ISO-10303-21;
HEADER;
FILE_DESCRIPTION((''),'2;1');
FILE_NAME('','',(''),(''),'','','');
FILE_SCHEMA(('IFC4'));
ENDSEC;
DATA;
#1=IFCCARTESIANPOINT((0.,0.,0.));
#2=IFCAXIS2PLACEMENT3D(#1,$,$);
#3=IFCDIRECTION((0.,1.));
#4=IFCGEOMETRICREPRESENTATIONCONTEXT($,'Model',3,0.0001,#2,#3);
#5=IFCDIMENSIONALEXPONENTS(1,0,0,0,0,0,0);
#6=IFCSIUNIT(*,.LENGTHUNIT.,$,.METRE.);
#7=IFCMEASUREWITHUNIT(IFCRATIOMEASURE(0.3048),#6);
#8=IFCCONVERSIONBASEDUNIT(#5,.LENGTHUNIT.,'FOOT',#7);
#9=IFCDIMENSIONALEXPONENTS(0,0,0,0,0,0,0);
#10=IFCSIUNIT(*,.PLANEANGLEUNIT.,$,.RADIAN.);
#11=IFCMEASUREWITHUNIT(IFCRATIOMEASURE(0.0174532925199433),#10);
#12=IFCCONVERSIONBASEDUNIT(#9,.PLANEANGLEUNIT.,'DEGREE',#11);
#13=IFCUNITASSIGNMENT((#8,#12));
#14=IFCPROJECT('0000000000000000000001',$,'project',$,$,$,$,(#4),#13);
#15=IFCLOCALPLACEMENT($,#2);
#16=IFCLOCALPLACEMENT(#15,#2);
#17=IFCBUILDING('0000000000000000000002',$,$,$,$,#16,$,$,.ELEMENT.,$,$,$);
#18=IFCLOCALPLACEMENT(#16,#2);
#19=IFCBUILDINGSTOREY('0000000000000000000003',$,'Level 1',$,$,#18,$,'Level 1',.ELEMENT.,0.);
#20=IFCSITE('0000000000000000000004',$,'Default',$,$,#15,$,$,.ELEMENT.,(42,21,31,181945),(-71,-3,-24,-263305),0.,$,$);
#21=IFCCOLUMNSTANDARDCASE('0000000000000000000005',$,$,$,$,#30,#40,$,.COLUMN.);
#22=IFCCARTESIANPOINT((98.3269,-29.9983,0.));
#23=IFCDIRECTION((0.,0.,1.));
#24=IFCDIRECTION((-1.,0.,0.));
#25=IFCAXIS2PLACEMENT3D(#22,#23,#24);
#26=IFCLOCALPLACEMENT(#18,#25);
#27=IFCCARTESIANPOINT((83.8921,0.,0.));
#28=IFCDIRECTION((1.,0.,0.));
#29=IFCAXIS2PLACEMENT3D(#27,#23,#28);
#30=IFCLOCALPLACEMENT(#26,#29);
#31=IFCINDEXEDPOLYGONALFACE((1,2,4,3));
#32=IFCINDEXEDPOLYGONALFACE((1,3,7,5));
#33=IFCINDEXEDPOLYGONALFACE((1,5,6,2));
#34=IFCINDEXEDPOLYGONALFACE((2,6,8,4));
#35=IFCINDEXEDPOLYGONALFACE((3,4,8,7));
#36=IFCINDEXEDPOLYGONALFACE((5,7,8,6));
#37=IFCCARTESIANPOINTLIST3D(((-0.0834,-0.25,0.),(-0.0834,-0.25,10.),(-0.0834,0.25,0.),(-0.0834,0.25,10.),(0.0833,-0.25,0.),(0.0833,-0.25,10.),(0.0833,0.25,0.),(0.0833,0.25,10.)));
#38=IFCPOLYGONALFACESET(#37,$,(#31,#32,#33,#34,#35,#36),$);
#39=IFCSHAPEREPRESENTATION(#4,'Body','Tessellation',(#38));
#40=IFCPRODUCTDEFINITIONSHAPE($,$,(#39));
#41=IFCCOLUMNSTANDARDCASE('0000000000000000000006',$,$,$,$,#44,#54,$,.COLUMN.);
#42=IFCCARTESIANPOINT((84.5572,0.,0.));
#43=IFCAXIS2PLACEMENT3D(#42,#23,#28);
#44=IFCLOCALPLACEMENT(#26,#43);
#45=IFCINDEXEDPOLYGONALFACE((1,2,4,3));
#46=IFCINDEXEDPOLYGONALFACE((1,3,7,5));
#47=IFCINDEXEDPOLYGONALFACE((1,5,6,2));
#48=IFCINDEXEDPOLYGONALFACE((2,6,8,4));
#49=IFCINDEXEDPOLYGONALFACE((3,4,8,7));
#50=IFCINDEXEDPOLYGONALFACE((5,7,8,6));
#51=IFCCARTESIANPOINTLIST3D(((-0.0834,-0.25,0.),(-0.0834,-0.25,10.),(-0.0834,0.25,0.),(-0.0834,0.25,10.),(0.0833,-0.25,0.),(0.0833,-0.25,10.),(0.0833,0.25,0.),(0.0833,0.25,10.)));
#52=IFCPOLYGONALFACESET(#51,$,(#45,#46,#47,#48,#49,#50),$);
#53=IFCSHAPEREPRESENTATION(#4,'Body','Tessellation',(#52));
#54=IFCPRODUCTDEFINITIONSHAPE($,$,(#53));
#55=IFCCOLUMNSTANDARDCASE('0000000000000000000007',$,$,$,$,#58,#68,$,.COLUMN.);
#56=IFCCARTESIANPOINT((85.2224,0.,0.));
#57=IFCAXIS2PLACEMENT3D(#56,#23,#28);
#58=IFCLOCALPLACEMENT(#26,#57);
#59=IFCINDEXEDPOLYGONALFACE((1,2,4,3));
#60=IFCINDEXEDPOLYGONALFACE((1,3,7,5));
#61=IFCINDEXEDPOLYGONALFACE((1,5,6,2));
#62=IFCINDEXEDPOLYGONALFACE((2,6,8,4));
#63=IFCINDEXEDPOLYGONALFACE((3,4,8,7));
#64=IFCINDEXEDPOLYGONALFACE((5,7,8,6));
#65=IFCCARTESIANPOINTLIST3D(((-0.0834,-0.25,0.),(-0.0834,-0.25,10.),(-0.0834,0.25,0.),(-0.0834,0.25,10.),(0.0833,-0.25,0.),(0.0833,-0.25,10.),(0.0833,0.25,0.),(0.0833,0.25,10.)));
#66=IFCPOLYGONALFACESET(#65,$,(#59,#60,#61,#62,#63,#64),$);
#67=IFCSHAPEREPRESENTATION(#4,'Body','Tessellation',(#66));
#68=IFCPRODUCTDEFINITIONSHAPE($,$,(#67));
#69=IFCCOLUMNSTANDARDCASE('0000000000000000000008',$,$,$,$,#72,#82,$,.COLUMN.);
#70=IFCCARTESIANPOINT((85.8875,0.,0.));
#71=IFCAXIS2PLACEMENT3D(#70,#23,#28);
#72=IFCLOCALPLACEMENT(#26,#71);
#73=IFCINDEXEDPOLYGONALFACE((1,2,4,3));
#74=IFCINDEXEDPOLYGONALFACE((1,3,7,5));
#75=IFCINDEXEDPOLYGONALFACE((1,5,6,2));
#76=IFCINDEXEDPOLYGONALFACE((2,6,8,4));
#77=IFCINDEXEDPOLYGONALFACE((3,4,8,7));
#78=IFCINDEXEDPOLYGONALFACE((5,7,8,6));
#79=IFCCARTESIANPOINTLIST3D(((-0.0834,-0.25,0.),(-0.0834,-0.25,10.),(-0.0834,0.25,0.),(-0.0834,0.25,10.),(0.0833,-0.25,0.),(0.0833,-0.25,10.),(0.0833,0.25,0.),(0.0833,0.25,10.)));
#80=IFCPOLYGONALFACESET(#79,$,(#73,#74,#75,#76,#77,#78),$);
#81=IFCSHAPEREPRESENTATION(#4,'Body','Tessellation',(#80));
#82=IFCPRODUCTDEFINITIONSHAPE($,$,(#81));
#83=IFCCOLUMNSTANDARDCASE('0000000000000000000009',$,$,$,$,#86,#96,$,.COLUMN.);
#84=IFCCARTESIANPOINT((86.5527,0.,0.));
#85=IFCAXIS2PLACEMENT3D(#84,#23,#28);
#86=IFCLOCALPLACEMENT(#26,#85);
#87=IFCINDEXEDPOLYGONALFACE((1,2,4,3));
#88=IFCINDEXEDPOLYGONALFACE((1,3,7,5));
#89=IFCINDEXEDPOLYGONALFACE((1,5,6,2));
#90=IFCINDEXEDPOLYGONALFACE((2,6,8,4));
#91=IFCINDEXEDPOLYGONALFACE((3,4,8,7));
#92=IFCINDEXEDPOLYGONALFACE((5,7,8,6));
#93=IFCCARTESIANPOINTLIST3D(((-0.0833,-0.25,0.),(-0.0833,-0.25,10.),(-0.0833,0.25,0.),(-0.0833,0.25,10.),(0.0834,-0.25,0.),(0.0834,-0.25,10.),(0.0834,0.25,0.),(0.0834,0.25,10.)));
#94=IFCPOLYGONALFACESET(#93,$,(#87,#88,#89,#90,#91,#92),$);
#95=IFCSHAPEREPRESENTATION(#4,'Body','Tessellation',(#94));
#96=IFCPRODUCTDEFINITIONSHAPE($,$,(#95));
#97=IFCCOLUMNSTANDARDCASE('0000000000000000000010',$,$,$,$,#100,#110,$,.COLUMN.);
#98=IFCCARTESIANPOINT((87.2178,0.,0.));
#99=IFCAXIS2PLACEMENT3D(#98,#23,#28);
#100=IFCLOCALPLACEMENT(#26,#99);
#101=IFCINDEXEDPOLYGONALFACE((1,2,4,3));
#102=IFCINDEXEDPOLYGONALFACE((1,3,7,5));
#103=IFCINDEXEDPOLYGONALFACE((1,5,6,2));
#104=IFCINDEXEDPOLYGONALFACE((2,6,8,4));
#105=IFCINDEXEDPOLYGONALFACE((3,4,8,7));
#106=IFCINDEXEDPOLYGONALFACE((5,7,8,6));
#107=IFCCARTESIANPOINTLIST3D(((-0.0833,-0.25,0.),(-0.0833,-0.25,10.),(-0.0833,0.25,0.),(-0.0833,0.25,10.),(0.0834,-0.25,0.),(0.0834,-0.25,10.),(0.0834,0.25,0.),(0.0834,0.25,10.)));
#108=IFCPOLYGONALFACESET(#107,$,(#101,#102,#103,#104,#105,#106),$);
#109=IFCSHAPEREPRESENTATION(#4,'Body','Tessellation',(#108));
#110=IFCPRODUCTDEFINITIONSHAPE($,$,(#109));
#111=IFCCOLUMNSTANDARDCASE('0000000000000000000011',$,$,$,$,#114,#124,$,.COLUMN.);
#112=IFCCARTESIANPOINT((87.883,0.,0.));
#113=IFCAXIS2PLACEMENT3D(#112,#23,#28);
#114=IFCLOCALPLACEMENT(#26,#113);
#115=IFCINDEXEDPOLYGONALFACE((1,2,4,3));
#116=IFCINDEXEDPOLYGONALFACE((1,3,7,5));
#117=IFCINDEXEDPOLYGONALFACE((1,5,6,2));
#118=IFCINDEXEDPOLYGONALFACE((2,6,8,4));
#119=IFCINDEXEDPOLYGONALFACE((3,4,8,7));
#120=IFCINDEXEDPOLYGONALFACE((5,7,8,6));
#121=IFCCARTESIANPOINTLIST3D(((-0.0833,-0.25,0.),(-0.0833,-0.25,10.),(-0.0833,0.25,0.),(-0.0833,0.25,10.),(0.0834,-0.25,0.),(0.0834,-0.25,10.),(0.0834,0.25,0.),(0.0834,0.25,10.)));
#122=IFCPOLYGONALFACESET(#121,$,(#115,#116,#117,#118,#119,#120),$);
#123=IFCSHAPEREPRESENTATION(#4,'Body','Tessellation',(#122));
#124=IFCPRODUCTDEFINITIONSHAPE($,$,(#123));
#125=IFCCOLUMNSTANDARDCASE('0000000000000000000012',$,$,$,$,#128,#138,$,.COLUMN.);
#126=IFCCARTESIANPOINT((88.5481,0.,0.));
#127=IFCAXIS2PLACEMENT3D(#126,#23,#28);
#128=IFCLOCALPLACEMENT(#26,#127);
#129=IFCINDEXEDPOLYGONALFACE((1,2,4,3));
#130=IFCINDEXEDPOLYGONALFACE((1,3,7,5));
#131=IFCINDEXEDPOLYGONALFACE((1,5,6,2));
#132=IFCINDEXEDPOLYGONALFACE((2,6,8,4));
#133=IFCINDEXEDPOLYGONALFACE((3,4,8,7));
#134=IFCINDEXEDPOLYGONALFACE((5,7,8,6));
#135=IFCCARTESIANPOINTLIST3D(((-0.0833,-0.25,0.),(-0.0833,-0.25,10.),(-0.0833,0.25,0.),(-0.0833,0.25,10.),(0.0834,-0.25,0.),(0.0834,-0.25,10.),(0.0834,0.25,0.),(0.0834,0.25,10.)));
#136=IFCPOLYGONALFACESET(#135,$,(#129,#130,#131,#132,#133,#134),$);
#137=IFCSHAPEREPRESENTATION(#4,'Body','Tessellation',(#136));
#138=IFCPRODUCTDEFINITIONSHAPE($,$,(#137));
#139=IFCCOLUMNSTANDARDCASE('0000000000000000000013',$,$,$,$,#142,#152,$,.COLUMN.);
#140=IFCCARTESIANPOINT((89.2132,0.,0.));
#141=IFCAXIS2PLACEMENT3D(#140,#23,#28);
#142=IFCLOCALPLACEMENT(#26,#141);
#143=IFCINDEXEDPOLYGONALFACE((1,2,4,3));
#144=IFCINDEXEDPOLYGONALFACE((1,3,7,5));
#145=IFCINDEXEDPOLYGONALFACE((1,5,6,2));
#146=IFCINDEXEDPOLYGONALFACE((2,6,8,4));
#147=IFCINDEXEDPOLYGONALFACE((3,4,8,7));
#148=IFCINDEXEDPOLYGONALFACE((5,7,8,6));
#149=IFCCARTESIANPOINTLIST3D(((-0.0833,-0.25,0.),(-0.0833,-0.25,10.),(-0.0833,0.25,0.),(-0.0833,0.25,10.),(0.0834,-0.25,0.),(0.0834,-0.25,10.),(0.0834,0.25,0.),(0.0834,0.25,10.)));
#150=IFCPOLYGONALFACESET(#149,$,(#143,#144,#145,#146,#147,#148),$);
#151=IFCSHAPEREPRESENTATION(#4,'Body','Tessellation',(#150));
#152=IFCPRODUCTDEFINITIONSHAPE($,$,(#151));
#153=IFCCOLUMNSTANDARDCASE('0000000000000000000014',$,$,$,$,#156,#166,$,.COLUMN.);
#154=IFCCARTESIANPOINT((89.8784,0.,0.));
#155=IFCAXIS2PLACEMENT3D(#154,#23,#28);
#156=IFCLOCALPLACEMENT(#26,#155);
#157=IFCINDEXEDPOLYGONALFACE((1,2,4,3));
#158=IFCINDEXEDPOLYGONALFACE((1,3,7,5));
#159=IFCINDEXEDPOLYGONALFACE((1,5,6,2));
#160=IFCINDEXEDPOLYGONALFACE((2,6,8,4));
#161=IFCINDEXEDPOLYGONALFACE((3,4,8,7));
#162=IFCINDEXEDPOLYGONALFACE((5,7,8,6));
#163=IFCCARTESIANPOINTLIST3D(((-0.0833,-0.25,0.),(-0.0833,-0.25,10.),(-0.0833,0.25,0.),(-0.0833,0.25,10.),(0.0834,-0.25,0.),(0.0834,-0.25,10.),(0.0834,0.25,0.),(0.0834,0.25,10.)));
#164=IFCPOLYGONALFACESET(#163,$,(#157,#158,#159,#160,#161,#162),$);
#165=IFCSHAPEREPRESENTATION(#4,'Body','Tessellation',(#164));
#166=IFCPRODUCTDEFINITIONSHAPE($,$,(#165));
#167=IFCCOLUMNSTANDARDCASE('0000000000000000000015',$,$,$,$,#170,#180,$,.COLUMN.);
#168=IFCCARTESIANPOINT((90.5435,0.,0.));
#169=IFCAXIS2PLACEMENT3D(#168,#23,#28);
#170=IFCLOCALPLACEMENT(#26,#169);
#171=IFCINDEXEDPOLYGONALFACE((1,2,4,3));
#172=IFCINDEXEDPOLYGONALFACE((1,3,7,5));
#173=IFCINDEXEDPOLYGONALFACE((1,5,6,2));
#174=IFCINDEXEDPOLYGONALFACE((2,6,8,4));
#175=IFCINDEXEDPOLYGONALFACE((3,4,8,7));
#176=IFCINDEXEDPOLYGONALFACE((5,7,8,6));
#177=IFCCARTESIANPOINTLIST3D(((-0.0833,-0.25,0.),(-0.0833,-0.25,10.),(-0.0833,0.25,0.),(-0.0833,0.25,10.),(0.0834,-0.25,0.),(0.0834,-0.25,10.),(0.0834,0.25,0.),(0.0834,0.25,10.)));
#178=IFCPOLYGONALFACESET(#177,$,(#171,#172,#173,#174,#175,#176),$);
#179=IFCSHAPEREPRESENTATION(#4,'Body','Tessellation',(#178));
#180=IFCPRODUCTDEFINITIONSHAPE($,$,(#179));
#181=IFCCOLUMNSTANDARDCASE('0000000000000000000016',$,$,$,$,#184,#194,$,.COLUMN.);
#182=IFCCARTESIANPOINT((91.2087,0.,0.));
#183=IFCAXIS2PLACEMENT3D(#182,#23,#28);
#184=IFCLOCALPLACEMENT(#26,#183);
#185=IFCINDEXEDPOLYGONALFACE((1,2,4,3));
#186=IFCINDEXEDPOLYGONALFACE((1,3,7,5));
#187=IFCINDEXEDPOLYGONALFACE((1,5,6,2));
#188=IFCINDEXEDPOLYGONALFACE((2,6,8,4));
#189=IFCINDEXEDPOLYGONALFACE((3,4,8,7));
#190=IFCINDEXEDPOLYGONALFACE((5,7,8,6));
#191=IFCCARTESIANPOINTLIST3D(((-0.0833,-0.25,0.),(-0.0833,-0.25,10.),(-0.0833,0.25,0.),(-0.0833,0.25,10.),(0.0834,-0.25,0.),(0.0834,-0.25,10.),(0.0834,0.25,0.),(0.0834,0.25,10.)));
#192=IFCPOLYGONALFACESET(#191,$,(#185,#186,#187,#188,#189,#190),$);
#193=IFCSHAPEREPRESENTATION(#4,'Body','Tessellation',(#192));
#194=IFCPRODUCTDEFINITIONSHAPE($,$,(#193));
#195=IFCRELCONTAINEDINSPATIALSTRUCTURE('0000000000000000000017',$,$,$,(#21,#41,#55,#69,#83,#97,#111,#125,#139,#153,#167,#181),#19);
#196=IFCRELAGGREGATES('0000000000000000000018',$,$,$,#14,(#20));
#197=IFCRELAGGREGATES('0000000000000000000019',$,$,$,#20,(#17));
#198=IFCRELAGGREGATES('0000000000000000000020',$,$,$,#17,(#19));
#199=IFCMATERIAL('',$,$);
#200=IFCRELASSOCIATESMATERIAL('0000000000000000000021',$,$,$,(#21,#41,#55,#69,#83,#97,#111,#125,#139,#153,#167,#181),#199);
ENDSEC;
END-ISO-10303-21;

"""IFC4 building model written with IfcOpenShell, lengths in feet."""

from ifc_helpers import new_model, entity, si_unit, converted_unit, direction, frame, origin, place, context, project, spatial, rectangle, extrude, material, element, save


model = new_model("IFC4")

# Units and contexts
model_context = context("Model", 3, precision=0.0001, world=origin(), true_north=direction((0.0, 1.0)))
ifc_project = project(units=[converted_unit("LENGTHUNIT", "FOOT", entity("IfcRatioMeasure", 0.3048), si_unit("LENGTHUNIT", "METRE"), dimensions=[1, 0, 0, 0, 0, 0, 0]), converted_unit("PLANEANGLEUNIT", "DEGREE", entity("IfcRatioMeasure", 0.0174532925199433), si_unit("PLANEANGLEUNIT", "RADIAN"), dimensions=[0, 0, 0, 0, 0, 0, 0])], contexts=[model_context])

# Site, building, storey
site_placement = place(None, origin())
site = spatial("IfcSite", under=ifc_project, at=site_placement, Name="Default", CompositionType="ELEMENT", RefLatitude=(42, 21, 31, 181945), RefLongitude=(-71, -3, -24, -263305), RefElevation=0.0)
building_placement = place(site_placement, origin())
building = spatial("IfcBuilding", under=site, at=building_placement, CompositionType="ELEMENT")
storey_placement = place(building_placement, origin())
storey = spatial("IfcBuildingStorey", under=building, at=storey_placement, Name="Level 1", LongName="Level 1", CompositionType="ELEMENT", Elevation=0.0)

# Columns
ifc_material = material(Name="")
placement = place(storey_placement, frame((98.3269, -29.9983, 0.0), z_axis=(0.0, 0.0, 1.0), x_axis=(-1.0, 0.0, 0.0)))
for number, where, z_axis, x_axis in (
    (1, (83.8921, 0.0, 0.0), (0.0, 0.0, 1.0), (1.0, 0.0, 0.0)),
    (2, (84.5572, 0.0, 0.0), (0.0, 0.0, 1.0), (1.0, 0.0, 0.0)),
    (3, (85.2224, 0.0, 0.0), (0.0, 0.0, 1.0), (1.0, 0.0, 0.0)),
    (4, (85.8875, 0.0, 0.0), (0.0, 0.0, 1.0), (1.0, 0.0, 0.0)),
    (5, (86.5527, 0.0, 0.0), (0.0, 0.0, 1.0), (1.0, 0.0, 0.0)),
    (6, (87.2178, 0.0, 0.0), (0.0, 0.0, 1.0), (1.0, 0.0, 0.0)),
    (7, (87.883, 0.0, 0.0), (0.0, 0.0, 1.0), (1.0, 0.0, 0.0)),
    (8, (88.5481, 0.0, 0.0), (0.0, 0.0, 1.0), (1.0, 0.0, 0.0)),
    (9, (89.2132, 0.0, 0.0), (0.0, 0.0, 1.0), (1.0, 0.0, 0.0)),
    (10, (89.8784, 0.0, 0.0), (0.0, 0.0, 1.0), (1.0, 0.0, 0.0)),
    (11, (90.5435, 0.0, 0.0), (0.0, 0.0, 1.0), (1.0, 0.0, 0.0)),
    (12, (91.2087, 0.0, 0.0), (0.0, 0.0, 1.0), (1.0, 0.0, 0.0)),
):
    element("IfcColumnStandardCase", number, at=place(placement, frame(where, z_axis=z_axis, x_axis=x_axis)), inside=storey, material=ifc_material, PredefinedType="COLUMN", context=model_context, shape_type="SweptSolid", body=[
        extrude(rectangle(XDim=0.1667, YDim=0.5), origin(), (0.0, 0.0, 1.0), 10.0),
    ])

save(model, "model.ifc")
